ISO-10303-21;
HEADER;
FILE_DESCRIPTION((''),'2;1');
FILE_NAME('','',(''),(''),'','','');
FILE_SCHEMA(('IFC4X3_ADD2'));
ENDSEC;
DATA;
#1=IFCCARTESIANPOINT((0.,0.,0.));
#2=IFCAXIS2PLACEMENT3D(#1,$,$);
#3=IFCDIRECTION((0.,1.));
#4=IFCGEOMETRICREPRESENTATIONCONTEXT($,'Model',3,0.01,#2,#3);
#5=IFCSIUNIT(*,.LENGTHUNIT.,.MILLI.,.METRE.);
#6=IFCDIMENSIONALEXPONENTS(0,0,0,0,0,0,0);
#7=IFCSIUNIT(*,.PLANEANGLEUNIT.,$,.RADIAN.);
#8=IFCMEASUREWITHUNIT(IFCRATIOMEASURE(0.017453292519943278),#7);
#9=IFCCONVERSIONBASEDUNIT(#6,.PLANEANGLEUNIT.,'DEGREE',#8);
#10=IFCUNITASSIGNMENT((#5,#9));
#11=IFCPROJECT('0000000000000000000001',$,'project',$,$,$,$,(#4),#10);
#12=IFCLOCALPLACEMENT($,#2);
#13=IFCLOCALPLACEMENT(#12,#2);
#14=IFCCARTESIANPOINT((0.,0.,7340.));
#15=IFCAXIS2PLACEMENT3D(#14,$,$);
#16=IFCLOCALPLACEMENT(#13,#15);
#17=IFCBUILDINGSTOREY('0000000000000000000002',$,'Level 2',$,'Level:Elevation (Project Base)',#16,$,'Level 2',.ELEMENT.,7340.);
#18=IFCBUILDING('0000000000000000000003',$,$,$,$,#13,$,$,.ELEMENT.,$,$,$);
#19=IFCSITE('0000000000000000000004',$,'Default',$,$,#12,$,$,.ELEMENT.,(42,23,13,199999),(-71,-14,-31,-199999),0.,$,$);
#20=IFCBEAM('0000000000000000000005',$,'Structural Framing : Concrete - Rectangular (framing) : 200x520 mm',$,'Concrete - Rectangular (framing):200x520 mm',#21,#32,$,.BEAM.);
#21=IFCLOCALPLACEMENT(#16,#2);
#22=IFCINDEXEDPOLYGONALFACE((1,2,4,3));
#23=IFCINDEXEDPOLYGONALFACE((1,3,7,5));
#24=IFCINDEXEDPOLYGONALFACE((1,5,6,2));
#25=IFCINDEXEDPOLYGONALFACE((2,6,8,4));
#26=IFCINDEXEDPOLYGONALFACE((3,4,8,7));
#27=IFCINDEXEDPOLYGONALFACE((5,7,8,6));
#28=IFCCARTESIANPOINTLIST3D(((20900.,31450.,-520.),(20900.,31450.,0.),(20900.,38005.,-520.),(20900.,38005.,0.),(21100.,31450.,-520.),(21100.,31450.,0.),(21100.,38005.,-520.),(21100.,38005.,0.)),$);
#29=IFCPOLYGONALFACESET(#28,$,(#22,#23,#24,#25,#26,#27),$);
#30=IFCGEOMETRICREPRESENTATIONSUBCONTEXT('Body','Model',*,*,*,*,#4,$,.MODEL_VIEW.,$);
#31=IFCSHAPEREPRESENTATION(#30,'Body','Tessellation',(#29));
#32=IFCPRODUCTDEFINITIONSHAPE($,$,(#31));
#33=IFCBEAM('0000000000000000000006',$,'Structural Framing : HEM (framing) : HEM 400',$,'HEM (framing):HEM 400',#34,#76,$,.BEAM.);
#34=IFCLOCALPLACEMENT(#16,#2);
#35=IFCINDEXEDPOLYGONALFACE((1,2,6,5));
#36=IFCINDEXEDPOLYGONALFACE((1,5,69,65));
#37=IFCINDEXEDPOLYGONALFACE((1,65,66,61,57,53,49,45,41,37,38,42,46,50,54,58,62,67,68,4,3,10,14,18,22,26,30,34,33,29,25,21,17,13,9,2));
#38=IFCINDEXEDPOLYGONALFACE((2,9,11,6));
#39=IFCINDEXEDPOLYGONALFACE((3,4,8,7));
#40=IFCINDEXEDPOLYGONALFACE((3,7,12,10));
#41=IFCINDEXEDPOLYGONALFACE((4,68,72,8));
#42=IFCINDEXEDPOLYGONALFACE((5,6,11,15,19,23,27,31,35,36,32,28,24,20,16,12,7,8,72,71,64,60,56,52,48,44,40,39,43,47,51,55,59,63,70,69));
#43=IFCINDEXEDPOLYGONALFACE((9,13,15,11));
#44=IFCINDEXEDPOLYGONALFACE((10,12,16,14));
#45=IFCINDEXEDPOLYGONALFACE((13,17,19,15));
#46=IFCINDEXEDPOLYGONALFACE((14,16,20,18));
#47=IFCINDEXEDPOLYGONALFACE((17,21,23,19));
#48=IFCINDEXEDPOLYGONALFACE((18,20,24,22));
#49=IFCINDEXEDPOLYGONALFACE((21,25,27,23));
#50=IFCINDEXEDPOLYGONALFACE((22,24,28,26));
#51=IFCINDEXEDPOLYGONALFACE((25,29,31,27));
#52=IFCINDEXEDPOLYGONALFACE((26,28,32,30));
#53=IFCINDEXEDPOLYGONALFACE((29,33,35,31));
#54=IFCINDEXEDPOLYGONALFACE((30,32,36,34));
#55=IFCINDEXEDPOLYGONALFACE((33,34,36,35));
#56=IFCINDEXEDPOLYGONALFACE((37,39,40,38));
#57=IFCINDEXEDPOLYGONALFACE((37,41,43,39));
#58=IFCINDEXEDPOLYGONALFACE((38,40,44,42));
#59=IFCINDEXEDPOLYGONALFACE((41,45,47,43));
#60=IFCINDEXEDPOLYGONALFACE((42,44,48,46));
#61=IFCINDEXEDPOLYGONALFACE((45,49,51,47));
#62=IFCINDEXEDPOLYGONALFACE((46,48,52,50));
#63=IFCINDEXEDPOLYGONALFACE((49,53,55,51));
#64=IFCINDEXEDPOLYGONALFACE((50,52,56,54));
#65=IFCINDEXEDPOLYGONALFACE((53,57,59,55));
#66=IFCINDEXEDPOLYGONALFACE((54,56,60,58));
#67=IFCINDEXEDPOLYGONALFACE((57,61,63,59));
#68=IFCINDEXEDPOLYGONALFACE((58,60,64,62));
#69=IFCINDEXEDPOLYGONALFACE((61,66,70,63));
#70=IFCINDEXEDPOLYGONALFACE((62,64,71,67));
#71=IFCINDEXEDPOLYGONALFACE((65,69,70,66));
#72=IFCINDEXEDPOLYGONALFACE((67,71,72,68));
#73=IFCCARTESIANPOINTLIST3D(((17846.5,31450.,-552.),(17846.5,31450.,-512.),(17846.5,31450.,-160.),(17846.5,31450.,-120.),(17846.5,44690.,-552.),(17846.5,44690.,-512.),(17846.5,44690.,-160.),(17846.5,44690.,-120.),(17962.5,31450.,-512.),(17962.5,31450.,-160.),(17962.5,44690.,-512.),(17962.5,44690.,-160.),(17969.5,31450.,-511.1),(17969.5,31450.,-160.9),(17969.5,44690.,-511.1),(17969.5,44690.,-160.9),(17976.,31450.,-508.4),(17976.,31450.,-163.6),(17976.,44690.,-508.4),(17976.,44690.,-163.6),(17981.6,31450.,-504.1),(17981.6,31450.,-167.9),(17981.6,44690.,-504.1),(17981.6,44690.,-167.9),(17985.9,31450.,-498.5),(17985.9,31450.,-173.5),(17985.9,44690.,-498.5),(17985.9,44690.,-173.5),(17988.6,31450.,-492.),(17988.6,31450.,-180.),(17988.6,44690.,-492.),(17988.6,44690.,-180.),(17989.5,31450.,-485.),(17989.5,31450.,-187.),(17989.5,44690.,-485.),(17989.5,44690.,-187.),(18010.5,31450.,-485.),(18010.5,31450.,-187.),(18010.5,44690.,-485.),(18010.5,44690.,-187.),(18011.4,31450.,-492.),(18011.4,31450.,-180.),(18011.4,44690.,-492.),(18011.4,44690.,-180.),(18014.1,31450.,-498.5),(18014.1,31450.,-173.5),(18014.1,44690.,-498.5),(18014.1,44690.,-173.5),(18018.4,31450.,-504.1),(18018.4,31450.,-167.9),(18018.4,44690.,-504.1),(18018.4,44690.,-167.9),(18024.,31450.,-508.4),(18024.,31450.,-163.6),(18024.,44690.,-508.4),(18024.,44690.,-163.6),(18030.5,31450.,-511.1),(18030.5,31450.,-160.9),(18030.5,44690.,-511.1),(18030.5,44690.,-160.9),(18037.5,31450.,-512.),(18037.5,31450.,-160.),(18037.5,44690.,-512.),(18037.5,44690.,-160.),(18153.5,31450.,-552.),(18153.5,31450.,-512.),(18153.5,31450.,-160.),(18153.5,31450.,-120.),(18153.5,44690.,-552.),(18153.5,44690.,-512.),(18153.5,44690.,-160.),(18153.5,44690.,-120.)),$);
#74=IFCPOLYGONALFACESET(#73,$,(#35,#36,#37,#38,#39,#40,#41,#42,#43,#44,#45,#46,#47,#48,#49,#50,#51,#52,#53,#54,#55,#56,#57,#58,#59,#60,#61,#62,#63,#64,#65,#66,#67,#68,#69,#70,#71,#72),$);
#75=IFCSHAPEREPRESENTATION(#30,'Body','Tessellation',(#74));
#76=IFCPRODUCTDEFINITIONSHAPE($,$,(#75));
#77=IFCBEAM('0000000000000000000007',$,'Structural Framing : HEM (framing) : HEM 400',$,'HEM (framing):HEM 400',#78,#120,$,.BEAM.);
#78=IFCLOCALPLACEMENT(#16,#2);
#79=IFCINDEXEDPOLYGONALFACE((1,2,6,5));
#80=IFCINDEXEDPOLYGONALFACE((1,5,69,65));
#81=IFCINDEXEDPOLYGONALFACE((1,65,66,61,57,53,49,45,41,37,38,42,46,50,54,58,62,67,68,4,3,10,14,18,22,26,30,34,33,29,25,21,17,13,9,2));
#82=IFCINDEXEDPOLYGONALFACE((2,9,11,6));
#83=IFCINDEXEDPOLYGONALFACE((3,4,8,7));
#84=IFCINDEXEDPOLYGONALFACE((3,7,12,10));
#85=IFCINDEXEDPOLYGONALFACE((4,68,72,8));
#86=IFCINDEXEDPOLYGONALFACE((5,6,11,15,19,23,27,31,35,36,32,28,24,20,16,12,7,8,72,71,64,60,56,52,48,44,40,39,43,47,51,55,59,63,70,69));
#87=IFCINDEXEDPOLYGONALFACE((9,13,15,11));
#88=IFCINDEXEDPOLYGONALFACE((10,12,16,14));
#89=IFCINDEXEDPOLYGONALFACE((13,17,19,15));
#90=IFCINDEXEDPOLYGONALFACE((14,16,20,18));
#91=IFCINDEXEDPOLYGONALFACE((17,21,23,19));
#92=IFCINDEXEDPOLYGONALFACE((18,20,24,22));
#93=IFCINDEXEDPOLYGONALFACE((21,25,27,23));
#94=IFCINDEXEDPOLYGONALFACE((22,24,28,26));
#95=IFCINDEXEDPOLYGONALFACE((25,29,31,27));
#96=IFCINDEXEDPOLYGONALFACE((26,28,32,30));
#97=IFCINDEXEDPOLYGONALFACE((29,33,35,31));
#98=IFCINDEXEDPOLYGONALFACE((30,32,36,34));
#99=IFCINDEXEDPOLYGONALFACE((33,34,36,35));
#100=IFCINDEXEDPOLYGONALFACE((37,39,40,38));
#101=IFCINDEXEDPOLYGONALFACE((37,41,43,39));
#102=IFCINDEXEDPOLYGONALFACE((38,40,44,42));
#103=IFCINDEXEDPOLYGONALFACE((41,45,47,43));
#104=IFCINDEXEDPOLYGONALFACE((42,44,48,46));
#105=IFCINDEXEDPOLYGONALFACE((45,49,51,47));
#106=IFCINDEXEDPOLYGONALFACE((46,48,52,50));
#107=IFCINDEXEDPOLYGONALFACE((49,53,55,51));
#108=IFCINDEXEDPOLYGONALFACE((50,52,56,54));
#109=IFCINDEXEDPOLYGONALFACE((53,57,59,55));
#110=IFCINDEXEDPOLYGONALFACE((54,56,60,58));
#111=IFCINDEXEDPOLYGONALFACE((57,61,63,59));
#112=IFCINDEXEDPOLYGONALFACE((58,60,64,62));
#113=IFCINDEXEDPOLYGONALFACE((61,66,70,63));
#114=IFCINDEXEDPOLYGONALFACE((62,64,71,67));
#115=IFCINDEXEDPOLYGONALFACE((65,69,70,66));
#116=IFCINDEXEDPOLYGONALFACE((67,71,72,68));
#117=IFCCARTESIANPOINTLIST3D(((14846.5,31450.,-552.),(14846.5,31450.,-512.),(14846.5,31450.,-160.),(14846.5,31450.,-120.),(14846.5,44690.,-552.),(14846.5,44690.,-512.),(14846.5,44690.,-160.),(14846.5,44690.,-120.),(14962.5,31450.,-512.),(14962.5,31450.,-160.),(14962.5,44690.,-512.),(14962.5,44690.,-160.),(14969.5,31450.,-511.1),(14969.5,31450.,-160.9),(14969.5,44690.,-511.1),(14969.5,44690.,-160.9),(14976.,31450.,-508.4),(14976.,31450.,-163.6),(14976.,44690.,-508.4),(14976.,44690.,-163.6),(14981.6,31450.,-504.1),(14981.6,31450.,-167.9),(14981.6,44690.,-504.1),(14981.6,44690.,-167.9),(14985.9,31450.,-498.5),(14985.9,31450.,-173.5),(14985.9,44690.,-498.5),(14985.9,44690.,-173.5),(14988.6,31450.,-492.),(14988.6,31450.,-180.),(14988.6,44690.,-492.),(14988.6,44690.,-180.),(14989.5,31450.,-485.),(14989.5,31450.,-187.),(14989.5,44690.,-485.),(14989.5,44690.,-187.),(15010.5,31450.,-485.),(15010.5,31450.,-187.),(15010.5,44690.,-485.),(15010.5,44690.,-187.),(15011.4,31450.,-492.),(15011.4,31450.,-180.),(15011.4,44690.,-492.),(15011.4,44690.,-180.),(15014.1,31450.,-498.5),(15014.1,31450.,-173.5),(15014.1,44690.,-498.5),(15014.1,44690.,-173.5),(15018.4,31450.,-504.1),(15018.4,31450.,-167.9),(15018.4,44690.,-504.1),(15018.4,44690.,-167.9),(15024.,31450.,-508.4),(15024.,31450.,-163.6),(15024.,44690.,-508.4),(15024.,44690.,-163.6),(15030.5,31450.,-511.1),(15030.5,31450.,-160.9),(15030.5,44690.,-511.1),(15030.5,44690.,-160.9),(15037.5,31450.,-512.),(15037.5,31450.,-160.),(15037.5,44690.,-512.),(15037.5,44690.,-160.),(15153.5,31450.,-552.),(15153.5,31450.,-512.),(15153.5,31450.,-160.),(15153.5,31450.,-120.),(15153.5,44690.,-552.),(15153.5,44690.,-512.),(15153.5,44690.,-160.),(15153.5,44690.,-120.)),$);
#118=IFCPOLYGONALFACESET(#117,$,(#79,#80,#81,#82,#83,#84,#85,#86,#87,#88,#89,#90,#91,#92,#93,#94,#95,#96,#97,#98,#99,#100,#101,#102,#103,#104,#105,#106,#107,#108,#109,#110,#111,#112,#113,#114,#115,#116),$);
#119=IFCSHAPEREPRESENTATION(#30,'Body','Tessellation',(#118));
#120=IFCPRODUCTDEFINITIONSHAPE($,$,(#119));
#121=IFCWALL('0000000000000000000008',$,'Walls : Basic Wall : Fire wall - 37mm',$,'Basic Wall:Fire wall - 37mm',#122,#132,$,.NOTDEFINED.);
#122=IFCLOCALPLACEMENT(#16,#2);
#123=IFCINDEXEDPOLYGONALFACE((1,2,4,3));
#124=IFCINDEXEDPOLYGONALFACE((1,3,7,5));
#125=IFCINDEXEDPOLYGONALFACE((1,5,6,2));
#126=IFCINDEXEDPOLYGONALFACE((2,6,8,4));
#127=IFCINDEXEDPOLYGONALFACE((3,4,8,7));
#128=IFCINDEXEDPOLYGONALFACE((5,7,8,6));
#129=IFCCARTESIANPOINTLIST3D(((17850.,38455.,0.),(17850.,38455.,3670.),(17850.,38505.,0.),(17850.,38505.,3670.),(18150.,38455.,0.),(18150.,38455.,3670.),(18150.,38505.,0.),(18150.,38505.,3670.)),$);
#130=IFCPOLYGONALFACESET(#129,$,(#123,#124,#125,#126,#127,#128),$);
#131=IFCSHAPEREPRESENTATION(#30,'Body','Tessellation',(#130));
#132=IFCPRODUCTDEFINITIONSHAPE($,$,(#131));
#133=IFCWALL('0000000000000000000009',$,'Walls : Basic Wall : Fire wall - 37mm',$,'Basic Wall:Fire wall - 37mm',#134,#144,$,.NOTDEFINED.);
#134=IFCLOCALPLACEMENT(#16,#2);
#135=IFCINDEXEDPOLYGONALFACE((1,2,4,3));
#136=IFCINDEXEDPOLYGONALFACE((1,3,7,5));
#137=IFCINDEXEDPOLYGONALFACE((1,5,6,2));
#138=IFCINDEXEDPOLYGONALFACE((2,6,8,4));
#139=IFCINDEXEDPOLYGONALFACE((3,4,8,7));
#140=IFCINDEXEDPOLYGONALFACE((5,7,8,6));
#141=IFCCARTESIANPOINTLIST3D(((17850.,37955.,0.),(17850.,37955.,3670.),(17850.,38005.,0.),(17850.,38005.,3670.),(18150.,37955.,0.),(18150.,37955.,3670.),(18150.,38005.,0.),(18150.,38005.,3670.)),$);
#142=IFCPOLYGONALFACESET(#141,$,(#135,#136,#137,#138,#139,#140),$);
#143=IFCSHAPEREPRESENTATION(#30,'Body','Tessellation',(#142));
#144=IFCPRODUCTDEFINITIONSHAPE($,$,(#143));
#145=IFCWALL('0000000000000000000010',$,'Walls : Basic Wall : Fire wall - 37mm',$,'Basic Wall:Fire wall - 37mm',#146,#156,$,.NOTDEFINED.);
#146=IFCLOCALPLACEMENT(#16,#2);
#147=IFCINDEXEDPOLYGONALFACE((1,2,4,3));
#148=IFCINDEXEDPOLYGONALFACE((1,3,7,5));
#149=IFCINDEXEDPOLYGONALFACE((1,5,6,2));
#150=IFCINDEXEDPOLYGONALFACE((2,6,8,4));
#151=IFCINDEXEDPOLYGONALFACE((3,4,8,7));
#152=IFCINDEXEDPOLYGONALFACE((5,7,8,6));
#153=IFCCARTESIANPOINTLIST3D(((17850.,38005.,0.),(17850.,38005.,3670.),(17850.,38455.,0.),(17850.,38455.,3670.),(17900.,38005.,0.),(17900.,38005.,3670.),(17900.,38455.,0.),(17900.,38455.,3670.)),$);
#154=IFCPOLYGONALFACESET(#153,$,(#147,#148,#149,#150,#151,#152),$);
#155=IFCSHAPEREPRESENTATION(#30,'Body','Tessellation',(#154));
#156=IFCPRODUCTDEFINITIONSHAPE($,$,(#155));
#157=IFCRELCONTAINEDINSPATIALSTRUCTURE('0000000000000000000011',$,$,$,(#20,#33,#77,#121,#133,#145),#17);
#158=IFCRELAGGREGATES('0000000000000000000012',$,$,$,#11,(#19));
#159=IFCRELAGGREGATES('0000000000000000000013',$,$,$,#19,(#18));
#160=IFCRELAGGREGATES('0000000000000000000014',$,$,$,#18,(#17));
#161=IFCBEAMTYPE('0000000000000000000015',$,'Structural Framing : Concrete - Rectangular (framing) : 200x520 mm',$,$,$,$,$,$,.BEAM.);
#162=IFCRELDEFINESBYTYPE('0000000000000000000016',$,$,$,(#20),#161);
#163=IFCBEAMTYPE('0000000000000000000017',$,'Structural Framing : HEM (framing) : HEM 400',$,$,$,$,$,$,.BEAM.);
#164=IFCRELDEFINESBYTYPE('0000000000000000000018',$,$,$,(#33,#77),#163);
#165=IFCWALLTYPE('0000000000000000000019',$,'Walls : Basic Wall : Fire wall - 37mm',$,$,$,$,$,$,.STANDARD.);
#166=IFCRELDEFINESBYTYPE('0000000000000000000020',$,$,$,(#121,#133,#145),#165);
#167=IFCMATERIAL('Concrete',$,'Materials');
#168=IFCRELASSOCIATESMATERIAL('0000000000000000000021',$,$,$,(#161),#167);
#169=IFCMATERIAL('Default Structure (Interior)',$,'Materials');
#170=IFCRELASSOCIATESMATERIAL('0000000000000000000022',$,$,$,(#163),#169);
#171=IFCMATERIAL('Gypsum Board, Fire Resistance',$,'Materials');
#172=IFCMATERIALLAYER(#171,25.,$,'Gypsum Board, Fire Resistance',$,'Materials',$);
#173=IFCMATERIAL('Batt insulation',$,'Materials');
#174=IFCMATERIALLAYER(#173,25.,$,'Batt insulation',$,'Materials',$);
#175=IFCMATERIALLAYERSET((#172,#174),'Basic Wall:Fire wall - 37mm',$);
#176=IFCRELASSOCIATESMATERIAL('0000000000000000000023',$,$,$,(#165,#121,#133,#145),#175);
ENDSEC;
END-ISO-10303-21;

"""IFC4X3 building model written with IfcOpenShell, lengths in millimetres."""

from ifc_helpers import new_model, entity, si_unit, converted_unit, direction, frame, frame_2d, origin, place, context, subcontext, project, spatial, polyline, circle_curve, parameter, trimmed, segment, composite_curve, rectangle, outline, extrude, source, transform, mapped, material, layer, layer_set, material_profile, profile_set, type_object, type_shapes, element, save


model = new_model("IFC4X3")

# Units and contexts
model_context = context("Model", 3, precision=0.01, world=origin(), true_north=direction((0.0, 1.0)))
body_context = subcontext(model_context, "Body", "Model", "MODEL_VIEW")
ifc_project = project(units=[si_unit("LENGTHUNIT", "METRE", prefix="MILLI"), converted_unit("PLANEANGLEUNIT", "DEGREE", entity("IfcRatioMeasure", 0.017453292519943278), si_unit("PLANEANGLEUNIT", "RADIAN"), dimensions=[0, 0, 0, 0, 0, 0, 0])], contexts=[model_context])

# Site, building, storey
site_placement = place(None, origin())
site = spatial("IfcSite", under=ifc_project, at=site_placement, Name="Default", CompositionType="ELEMENT", RefLatitude=(42, 23, 13, 199999), RefLongitude=(-71, -14, -31, -199999), RefElevation=0.0)
building_placement = place(site_placement, origin())
building = spatial("IfcBuilding", under=site, at=building_placement, CompositionType="ELEMENT")
storey_placement = place(building_placement, frame((0.0, 0.0, 7340.0)))
storey = spatial("IfcBuildingStorey", under=building, at=storey_placement, Name="Level 2", ObjectType="Level:Elevation (Project Base)", LongName="Level 2", CompositionType="ELEMENT", Elevation=7340.0)

# Beams
ifc_material_1 = material(Name="Concrete", Category="Materials")
ifc_material_profile_1 = material_profile(ifc_material_1, rectangle(XDim=520.0, YDim=200.0, at=frame_2d((0.0, 0.0), x_axis=(1.0, 0.0))), Name="200x520 mm")
ifc_profile_set_1 = profile_set([ifc_material_profile_1], Name="200x520 mm")
beam_type_1 = type_object("IfcBeamType", Name="Structural Framing : Concrete - Rectangular (framing) : 200x520 mm", PredefinedType="BEAM", material=ifc_profile_set_1)
shared_shape_1 = source(origin(), body_context, "Body", "SweptSolid", [
    extrude(rectangle(XDim=520.0, YDim=200.0, at=frame_2d((0.0, 0.0), x_axis=(1.0, 0.0))), frame((-1165.0, 0.0, 0.0), z_axis=(1.0, 0.0, 0.0), x_axis=(0.0, 0.0, -1.0)), (0.0, 0.0, 1.0), 6555.0),
])
type_shapes(beam_type_1, [shared_shape_1])
beam_placement = place(storey_placement, frame((21000.0, 36840.0, -260.0), z_axis=(0.0, 0.0, 1.0), x_axis=(0.0, -1.0, 0.0)))
element("IfcBeam", 1, at=beam_placement, inside=storey, type_object=beam_type_1, Name="Structural Framing : Concrete - Rectangular (framing) : 200x520 mm", ObjectType="Concrete - Rectangular (framing):200x520 mm", PredefinedType="BEAM", context=body_context, shape_type="MappedRepresentation", body=[
    mapped(shared_shape_1, transform((0.0, 0.0, 0.0), scale=1.0)),
])
ifc_material_2 = material(Name="Default Structure (Interior)", Category="Materials")
ifc_material_profile_2 = material_profile(ifc_material_2, outline(composite_curve([segment(polyline([(176.0, -153.5), (216.0, -153.5)]), True, "CONTINUOUS"), segment(polyline([(216.0, -153.5), (216.0, 153.5)]), True, "CONTINUOUS"), segment(polyline([(216.0, 153.5), (176.0, 153.5)]), True, "CONTINUOUS"), segment(polyline([(176.0, 153.5), (176.0, 37.5)]), True, "CONTINUOUS"), segment(trimmed(circle_curve(frame_2d((149.0, 37.5), x_axis=(1.0, 0.0)), 27.0), [parameter(270.0)], [parameter(0.0)], True, "PARAMETER"), False, "CONTINUOUS"), segment(polyline([(149.0, 10.5), (-149.0, 10.5)]), True, "CONTINUOUS"), segment(trimmed(circle_curve(frame_2d((-149.0, 37.5), x_axis=(0.0, -1.0)), 27.0), [parameter(270.0)], [parameter(0.0)], True, "PARAMETER"), False, "CONTINUOUS"), segment(polyline([(-176.0, 37.5), (-176.0, 153.5)]), True, "CONTINUOUS"), segment(polyline([(-176.0, 153.5), (-216.0, 153.5)]), True, "CONTINUOUS"), segment(polyline([(-216.0, 153.5), (-216.0, -153.5)]), True, "CONTINUOUS"), segment(polyline([(-216.0, -153.5), (-176.0, -153.5)]), True, "CONTINUOUS"), segment(polyline([(-176.0, -153.5), (-176.0, -37.5)]), True, "CONTINUOUS"), segment(trimmed(circle_curve(frame_2d((-149.0, -37.5), x_axis=(-1.0, 0.0)), 27.0), [parameter(270.0)], [parameter(0.0)], True, "PARAMETER"), False, "CONTINUOUS"), segment(polyline([(-149.0, -10.5), (149.0, -10.5)]), True, "CONTINUOUS"), segment(trimmed(circle_curve(frame_2d((149.0, -37.5), x_axis=(0.0, 1.0)), 27.0), [parameter(270.0)], [parameter(0.0)], True, "PARAMETER"), False, "CONTINUOUS"), segment(polyline([(176.0, -37.5), (176.0, -153.5)]), True, "CONTINUOUS")], self_intersect=False)), Name="HEM 400")
ifc_profile_set_2 = profile_set([ifc_material_profile_2], Name="HEM 400")
beam_type_2 = type_object("IfcBeamType", Name="Structural Framing : HEM (framing) : HEM 400", PredefinedType="BEAM", material=ifc_profile_set_2)
shared_shape_2 = source(origin(), body_context, "Body", "SweptSolid", [
    extrude(outline(composite_curve([segment(polyline([(176.0, -153.5), (216.0, -153.5)]), True, "CONTINUOUS"), segment(polyline([(216.0, -153.5), (216.0, 153.5)]), True, "CONTINUOUS"), segment(polyline([(216.0, 153.5), (176.0, 153.5)]), True, "CONTINUOUS"), segment(polyline([(176.0, 153.5), (176.0, 37.5)]), True, "CONTINUOUS"), segment(trimmed(circle_curve(frame_2d((149.0, 37.5), x_axis=(1.0, 0.0)), 27.0), [parameter(270.0)], [parameter(0.0)], True, "PARAMETER"), False, "CONTINUOUS"), segment(polyline([(149.0, 10.5), (-149.0, 10.5)]), True, "CONTINUOUS"), segment(trimmed(circle_curve(frame_2d((-149.0, 37.5), x_axis=(0.0, -1.0)), 27.0), [parameter(270.0)], [parameter(0.0)], True, "PARAMETER"), False, "CONTINUOUS"), segment(polyline([(-176.0, 37.5), (-176.0, 153.5)]), True, "CONTINUOUS"), segment(polyline([(-176.0, 153.5), (-216.0, 153.5)]), True, "CONTINUOUS"), segment(polyline([(-216.0, 153.5), (-216.0, -153.5)]), True, "CONTINUOUS"), segment(polyline([(-216.0, -153.5), (-176.0, -153.5)]), True, "CONTINUOUS"), segment(polyline([(-176.0, -153.5), (-176.0, -37.5)]), True, "CONTINUOUS"), segment(trimmed(circle_curve(frame_2d((-149.0, -37.5), x_axis=(-1.0, 0.0)), 27.0), [parameter(270.0)], [parameter(0.0)], True, "PARAMETER"), False, "CONTINUOUS"), segment(polyline([(-149.0, -10.5), (149.0, -10.5)]), True, "CONTINUOUS"), segment(trimmed(circle_curve(frame_2d((149.0, -37.5), x_axis=(0.0, 1.0)), 27.0), [parameter(270.0)], [parameter(0.0)], True, "PARAMETER"), False, "CONTINUOUS"), segment(polyline([(176.0, -37.5), (176.0, -153.5)]), True, "CONTINUOUS")], self_intersect=False)), frame((-1350.0, 0.0, 0.0), z_axis=(1.0, 0.0, 0.0), x_axis=(0.0, 0.0, -1.0)), (0.0, 0.0, 1.0), 13240.0),
])
type_shapes(beam_type_2, [shared_shape_2])
for number, where, z_axis, x_axis, name in (
    (2, (18000.0, 43340.0, -336.0), (0.0, 0.0, 1.0), (0.0, -1.0, 0.0), "Structural Framing : HEM (framing) : HEM 400"),
    (3, (15000.0, 43340.0, -336.0), (0.0, 0.0, 1.0), (0.0, -1.0, 0.0), "Structural Framing : HEM (framing) : HEM 400"),
):
    element("IfcBeam", number, at=place(storey_placement, frame(where, z_axis=z_axis, x_axis=x_axis)), inside=storey, type_object=beam_type_2, Name=name, ObjectType="HEM (framing):HEM 400", PredefinedType="BEAM", context=body_context, shape_type="MappedRepresentation", body=[
        mapped(shared_shape_2, transform((0.0, 0.0, 0.0), scale=1.0)),
    ])

# Walls
ifc_material_3 = material(Name="Gypsum Board, Fire Resistance", Category="Materials")
ifc_layer_1 = layer(ifc_material_3, 25.0, Name="Gypsum Board, Fire Resistance", Category="Materials")
ifc_material_4 = material(Name="Batt insulation", Category="Materials")
ifc_layer_2 = layer(ifc_material_4, 25.0, Name="Batt insulation", Category="Materials")
ifc_layer_set = layer_set([ifc_layer_1, ifc_layer_2], Name="Basic Wall:Fire wall - 37mm")
wall_type = type_object("IfcWallType", Name="Walls : Basic Wall : Fire wall - 37mm", PredefinedType="STANDARD", material=ifc_layer_set)
for number, where, name in (
    (4, (17850.0, 38480.0, 0.0), "Walls : Basic Wall : Fire wall - 37mm"),
    (5, (17850.0, 37980.0, 0.0), "Walls : Basic Wall : Fire wall - 37mm"),
):
    element("IfcWall", number, at=place(storey_placement, frame(where)), inside=storey, type_object=wall_type, material=ifc_layer_set, Name=name, ObjectType="Basic Wall:Fire wall - 37mm", PredefinedType="NOTDEFINED", context=body_context, shape_type="SweptSolid", body=[
        extrude(rectangle(XDim=300.0, YDim=50.0, at=frame_2d((150.0, 0.0), x_axis=(-1.0, 0.0))), origin(), (0.0, 0.0, 1.0), 3670.0),
    ])
for number, where, z_axis, x_axis, name in (
    (6, (17875.0, 38455.0, 0.0), (0.0, 0.0, 1.0), (0.0, -1.0, 0.0), "Walls : Basic Wall : Fire wall - 37mm"),
):
    element("IfcWall", number, at=place(storey_placement, frame(where, z_axis=z_axis, x_axis=x_axis)), inside=storey, type_object=wall_type, material=ifc_layer_set, Name=name, ObjectType="Basic Wall:Fire wall - 37mm", PredefinedType="NOTDEFINED", context=body_context, shape_type="SweptSolid", body=[
        extrude(rectangle(XDim=450.0, YDim=50.0, at=frame_2d((225.0, 0.0), x_axis=(-1.0, 0.0))), origin(), (0.0, 0.0, 1.0), 3670.0),
    ])

save(model, "model.ifc")
